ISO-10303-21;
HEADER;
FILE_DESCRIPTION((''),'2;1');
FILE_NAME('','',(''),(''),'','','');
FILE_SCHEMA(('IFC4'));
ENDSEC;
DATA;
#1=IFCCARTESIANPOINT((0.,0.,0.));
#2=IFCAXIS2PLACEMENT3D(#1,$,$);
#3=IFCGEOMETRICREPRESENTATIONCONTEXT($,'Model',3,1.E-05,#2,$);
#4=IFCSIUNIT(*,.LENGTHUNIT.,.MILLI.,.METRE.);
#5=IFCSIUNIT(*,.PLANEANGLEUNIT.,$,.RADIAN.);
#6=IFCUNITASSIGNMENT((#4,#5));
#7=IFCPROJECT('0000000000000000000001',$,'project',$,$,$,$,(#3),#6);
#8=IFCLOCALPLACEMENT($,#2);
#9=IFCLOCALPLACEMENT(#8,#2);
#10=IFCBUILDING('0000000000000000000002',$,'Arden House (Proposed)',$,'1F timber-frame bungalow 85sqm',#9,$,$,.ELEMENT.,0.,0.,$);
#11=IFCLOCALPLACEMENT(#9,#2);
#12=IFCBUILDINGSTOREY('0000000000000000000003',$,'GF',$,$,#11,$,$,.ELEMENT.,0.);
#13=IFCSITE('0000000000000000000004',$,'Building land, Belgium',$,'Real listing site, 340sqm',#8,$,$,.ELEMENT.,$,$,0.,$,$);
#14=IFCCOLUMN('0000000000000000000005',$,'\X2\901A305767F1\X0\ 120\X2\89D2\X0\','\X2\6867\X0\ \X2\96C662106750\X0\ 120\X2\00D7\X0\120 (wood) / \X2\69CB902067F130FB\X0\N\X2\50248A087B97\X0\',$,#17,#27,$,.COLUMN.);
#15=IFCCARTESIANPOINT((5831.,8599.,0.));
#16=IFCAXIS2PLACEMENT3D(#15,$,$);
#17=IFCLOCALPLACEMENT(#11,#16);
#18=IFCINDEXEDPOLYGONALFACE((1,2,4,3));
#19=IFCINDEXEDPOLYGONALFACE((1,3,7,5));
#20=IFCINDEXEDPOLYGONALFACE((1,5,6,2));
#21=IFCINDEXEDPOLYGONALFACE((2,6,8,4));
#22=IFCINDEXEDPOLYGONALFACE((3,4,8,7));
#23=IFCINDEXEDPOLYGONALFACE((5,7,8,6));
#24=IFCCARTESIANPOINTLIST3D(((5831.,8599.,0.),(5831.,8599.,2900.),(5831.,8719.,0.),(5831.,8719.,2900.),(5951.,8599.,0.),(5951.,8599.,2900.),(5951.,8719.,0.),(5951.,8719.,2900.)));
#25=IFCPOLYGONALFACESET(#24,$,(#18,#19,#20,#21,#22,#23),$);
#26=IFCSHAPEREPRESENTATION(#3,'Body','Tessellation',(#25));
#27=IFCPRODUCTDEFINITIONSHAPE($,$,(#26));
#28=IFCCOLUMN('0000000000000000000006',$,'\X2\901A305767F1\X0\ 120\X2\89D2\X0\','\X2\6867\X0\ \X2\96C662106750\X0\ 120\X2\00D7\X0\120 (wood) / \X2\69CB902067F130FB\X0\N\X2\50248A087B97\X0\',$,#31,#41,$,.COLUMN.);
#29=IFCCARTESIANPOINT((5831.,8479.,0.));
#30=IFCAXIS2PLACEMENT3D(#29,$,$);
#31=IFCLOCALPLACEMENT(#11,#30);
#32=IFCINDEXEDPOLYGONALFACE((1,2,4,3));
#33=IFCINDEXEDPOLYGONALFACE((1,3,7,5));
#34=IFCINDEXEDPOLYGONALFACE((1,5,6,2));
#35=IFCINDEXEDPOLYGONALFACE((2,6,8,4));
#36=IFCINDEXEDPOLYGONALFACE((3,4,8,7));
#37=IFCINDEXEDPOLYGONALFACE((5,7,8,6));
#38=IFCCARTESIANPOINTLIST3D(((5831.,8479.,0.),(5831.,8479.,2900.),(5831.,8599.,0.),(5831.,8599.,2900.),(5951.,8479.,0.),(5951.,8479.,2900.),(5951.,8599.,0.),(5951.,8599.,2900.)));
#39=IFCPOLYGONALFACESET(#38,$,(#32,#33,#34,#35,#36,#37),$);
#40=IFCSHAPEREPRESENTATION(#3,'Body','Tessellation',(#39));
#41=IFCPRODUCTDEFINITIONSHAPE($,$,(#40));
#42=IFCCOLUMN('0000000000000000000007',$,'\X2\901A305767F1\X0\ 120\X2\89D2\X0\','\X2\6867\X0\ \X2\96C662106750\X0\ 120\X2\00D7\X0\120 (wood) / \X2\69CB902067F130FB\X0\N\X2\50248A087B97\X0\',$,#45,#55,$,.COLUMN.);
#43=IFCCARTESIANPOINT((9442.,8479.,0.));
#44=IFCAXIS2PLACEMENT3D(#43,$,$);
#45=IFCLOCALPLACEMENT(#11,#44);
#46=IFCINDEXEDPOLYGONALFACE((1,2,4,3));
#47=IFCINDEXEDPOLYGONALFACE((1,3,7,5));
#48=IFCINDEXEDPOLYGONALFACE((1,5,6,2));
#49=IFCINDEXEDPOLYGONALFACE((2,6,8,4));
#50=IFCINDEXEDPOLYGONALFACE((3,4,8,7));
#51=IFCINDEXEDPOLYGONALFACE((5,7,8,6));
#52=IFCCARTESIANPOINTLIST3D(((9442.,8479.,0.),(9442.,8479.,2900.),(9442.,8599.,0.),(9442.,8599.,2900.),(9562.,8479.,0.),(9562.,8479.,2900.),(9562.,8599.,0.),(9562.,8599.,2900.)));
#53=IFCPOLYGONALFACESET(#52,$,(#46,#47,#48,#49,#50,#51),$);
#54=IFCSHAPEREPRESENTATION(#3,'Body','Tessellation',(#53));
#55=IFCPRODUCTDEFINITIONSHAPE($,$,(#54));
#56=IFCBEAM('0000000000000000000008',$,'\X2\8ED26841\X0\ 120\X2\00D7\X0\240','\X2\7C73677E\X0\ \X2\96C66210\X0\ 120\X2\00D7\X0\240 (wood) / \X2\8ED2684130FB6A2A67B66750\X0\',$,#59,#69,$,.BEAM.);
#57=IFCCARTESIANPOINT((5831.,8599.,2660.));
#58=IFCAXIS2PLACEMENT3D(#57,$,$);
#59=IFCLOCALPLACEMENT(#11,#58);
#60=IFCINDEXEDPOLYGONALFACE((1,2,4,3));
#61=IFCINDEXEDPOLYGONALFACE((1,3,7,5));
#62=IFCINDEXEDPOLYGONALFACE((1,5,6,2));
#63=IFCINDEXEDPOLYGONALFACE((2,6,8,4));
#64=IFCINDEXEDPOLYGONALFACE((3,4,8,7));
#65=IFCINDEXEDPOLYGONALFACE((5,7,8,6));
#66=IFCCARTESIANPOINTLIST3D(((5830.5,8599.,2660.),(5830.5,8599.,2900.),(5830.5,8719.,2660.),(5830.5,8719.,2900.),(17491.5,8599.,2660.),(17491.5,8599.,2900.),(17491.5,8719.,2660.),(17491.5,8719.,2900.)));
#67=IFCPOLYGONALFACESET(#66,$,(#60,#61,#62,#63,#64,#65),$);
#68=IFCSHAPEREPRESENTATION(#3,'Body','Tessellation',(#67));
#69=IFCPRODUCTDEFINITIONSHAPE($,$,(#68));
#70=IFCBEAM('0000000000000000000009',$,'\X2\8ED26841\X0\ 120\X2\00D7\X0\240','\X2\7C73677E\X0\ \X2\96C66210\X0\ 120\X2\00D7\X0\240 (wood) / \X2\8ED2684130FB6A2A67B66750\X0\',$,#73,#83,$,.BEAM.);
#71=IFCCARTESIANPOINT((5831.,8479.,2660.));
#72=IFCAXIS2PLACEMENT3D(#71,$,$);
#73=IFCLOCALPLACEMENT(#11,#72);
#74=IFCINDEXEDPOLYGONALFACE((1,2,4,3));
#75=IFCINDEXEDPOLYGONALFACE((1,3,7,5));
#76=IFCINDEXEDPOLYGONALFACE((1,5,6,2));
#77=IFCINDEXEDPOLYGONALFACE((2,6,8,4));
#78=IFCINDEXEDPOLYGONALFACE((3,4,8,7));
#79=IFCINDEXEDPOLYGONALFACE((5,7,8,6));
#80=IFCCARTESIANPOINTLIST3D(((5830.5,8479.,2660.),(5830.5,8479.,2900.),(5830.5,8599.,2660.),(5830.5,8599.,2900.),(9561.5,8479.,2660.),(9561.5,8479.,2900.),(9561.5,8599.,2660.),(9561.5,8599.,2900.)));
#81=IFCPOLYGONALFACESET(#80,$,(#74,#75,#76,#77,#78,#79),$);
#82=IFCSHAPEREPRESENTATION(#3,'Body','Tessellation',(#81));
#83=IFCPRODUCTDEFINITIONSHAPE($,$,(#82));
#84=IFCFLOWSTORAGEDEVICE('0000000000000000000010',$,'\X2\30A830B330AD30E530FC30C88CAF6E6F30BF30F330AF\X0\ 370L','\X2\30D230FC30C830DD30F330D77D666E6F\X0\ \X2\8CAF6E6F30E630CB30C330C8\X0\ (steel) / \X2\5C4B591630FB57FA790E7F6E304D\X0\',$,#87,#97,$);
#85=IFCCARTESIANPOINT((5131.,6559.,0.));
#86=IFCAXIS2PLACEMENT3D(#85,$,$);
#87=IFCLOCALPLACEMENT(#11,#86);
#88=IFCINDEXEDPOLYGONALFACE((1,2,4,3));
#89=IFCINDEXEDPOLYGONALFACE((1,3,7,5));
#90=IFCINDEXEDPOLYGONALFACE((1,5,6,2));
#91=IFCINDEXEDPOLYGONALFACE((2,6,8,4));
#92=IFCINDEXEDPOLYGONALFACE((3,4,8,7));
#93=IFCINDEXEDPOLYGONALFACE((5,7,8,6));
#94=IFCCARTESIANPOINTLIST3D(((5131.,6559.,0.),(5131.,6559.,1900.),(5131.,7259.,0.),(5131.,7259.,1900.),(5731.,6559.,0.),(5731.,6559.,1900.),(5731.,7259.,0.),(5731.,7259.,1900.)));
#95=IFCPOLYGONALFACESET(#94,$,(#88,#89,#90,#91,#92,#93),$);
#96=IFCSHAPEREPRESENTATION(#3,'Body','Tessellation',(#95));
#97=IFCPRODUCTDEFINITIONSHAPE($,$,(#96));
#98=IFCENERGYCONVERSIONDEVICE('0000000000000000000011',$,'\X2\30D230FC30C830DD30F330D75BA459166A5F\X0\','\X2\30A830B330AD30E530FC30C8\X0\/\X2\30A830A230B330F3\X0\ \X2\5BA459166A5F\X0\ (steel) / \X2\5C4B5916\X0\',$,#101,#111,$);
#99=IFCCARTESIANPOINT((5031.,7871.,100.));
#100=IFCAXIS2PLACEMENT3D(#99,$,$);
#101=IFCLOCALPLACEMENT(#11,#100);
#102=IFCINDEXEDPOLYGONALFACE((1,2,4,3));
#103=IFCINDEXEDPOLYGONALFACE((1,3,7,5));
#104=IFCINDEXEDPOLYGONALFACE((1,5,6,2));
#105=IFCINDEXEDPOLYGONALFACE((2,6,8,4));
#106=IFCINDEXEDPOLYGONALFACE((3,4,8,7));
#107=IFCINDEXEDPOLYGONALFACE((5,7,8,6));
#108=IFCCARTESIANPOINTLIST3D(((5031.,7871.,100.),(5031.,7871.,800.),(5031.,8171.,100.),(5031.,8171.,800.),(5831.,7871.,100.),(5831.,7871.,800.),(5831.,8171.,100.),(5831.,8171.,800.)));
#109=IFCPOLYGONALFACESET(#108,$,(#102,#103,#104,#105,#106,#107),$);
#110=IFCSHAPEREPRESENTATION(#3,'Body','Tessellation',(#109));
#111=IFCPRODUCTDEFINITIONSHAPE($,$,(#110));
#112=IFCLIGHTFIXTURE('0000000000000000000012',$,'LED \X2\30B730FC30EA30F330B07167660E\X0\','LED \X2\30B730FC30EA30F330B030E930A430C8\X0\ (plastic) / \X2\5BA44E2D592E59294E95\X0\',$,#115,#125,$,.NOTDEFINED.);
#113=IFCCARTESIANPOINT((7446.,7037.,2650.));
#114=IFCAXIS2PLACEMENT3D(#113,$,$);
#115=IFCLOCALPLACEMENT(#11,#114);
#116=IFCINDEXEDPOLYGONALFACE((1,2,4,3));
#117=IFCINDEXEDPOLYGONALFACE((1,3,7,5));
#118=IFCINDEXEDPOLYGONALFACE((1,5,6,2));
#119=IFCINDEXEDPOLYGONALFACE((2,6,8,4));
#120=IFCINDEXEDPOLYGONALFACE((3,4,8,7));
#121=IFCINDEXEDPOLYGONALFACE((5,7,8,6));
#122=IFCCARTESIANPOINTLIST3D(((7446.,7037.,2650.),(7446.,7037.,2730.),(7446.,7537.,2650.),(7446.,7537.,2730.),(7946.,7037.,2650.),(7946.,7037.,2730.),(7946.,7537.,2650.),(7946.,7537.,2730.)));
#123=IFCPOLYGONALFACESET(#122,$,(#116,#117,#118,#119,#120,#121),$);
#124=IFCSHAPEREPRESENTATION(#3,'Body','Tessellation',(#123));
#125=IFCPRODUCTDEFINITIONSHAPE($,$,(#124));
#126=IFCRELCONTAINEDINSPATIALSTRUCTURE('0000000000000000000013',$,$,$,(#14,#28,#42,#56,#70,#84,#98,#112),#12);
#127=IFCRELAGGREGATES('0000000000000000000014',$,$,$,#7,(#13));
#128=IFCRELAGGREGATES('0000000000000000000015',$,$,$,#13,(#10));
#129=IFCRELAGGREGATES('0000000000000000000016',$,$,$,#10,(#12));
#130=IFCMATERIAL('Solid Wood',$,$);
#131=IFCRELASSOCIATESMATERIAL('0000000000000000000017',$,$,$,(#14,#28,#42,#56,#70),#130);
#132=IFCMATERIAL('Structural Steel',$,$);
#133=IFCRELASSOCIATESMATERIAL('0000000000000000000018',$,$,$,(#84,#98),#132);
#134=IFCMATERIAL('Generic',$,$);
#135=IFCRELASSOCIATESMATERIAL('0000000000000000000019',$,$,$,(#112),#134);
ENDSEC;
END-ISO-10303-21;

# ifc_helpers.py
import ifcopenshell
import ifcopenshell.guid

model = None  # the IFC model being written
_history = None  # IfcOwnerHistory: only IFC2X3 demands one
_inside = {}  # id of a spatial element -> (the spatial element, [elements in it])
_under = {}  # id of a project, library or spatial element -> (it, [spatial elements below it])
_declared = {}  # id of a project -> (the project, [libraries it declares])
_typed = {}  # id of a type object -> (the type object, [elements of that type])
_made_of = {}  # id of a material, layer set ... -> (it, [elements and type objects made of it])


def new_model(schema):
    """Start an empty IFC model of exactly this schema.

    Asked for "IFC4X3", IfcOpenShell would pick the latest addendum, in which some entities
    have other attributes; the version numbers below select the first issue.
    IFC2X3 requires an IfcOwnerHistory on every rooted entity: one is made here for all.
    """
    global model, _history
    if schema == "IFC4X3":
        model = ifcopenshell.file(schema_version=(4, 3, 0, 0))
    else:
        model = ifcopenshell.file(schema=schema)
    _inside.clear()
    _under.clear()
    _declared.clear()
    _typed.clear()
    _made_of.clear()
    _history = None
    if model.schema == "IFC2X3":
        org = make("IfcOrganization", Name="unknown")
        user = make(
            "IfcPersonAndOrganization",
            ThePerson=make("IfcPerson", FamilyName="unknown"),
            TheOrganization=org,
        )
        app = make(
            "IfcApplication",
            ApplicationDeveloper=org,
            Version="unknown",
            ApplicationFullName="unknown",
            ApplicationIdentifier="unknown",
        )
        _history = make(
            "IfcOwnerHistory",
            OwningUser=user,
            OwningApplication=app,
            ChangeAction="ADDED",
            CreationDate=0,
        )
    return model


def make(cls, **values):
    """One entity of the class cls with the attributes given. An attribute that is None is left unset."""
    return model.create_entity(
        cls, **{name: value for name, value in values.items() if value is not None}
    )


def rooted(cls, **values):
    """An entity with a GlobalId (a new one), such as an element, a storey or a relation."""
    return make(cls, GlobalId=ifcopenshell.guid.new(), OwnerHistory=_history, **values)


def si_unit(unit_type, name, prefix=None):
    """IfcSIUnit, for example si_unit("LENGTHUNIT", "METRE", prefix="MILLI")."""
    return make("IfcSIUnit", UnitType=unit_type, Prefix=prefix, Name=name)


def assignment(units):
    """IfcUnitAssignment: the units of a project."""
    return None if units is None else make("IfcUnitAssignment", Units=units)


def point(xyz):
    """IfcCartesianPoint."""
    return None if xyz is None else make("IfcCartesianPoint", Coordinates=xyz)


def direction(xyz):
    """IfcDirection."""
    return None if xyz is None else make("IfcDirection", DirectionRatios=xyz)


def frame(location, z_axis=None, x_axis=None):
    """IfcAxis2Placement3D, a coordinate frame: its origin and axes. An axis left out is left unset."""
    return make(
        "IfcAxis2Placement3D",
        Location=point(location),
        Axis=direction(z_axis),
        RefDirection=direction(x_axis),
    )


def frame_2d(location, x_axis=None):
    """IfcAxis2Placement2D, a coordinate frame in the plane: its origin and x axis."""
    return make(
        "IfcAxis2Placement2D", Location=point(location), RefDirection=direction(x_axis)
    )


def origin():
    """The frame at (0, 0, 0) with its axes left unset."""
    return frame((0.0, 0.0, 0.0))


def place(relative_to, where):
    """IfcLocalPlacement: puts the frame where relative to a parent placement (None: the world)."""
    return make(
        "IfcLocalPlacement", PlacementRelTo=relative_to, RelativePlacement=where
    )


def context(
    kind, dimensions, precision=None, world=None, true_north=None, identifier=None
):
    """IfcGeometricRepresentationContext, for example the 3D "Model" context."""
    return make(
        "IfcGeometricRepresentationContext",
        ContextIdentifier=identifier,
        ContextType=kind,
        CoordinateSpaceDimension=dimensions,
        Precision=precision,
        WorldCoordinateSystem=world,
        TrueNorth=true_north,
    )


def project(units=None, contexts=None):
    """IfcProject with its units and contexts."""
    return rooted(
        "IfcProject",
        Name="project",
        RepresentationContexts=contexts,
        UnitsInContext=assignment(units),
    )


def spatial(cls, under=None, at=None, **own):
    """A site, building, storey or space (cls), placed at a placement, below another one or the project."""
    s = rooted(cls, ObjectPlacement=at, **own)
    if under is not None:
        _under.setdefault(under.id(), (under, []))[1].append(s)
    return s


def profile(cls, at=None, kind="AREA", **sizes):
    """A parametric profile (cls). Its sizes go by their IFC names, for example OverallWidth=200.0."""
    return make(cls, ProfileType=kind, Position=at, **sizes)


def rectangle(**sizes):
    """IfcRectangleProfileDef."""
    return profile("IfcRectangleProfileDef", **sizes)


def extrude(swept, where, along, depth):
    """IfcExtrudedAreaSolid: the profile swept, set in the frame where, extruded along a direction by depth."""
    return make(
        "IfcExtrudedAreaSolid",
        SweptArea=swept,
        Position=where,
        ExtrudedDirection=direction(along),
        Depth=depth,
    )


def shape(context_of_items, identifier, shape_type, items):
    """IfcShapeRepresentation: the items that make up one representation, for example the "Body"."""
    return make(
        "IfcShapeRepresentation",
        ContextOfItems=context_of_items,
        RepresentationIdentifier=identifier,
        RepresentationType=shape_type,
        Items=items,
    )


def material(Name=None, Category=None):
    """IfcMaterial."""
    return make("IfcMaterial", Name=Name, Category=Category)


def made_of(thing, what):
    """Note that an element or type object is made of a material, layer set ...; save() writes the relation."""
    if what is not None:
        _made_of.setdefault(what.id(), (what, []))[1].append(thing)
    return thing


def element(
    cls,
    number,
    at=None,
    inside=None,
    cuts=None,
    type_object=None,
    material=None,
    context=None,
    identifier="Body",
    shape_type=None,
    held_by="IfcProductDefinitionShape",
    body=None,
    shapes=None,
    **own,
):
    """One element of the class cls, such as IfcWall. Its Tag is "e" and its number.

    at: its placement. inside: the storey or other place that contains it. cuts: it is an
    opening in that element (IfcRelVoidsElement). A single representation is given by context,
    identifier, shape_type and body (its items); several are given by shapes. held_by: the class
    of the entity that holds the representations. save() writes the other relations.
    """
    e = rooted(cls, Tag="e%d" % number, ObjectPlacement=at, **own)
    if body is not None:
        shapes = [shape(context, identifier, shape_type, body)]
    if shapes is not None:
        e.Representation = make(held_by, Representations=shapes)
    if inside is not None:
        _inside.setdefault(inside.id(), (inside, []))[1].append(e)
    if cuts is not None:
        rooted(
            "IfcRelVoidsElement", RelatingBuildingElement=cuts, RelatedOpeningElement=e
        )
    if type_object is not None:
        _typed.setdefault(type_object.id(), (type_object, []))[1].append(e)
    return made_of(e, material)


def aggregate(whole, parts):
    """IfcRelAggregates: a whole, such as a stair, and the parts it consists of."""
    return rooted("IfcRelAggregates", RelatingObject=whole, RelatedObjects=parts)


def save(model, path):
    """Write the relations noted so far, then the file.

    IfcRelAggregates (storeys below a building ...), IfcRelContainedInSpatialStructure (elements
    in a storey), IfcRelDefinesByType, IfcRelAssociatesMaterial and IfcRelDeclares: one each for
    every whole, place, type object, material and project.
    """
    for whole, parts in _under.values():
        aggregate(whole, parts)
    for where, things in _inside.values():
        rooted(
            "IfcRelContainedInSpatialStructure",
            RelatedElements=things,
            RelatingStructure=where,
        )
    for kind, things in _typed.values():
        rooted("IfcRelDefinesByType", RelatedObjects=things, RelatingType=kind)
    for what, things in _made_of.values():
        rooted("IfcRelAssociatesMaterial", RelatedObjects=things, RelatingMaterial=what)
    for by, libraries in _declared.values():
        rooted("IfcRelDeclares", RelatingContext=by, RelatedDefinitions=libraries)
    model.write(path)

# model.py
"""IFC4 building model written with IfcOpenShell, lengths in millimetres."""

from ifc_helpers import new_model, si_unit, frame, frame_2d, origin, place, context, project, spatial, rectangle, extrude, material, element, save


model = new_model("IFC4")

# Units and contexts
model_context = context("Model", 3, precision=1e-05, world=origin())
ifc_project = project(units=[si_unit("LENGTHUNIT", "METRE", prefix="MILLI"), si_unit("PLANEANGLEUNIT", "RADIAN")], contexts=[model_context])

# Site, building, storey
site_placement = place(None, origin())
site = spatial("IfcSite", under=ifc_project, at=site_placement, Name="Building land, Belgium", ObjectType="Real listing site, 340sqm", CompositionType="ELEMENT", RefElevation=0.0)
building_placement = place(site_placement, origin())
building = spatial("IfcBuilding", under=site, at=building_placement, Name="Arden House (Proposed)", ObjectType="1F timber-frame bungalow 85sqm", CompositionType="ELEMENT", ElevationOfRefHeight=0.0, ElevationOfTerrain=0.0)
storey_placement = place(building_placement, origin())
storey = spatial("IfcBuildingStorey", under=building, at=storey_placement, Name="GF", CompositionType="ELEMENT", Elevation=0.0)

# Columns
ifc_material_1 = material(Name="Solid Wood")
column_1_placement = place(storey_placement, frame((5831.0, 8599.0, 0.0)))
element("IfcColumn", 1, at=column_1_placement, inside=storey, material=ifc_material_1, Name="通し柱 120角", Description="桧 集成材 120×120 (wood) / 構造柱・N値計算", PredefinedType="COLUMN", context=model_context, shape_type="SweptSolid", body=[
    extrude(rectangle(XDim=120.0, YDim=120.0, at=frame_2d((60.0, 60.0))), frame((5831.0, 8599.0, 0.0)), (0.0, 0.0, 1.0), 2900.0),
])
column_2_placement = place(storey_placement, frame((5831.0, 8479.0, 0.0)))
element("IfcColumn", 2, at=column_2_placement, inside=storey, material=ifc_material_1, Name="通し柱 120角", Description="桧 集成材 120×120 (wood) / 構造柱・N値計算", PredefinedType="COLUMN", context=model_context, shape_type="SweptSolid", body=[
    extrude(rectangle(XDim=120.0, YDim=120.0, at=frame_2d((60.0, 60.0))), frame((5831.0, 8479.0, 0.0)), (0.0, 0.0, 1.0), 2900.0),
])
column_3_placement = place(storey_placement, frame((9442.0, 8479.0, 0.0)))
element("IfcColumn", 3, at=column_3_placement, inside=storey, material=ifc_material_1, Name="通し柱 120角", Description="桧 集成材 120×120 (wood) / 構造柱・N値計算", PredefinedType="COLUMN", context=model_context, shape_type="SweptSolid", body=[
    extrude(rectangle(XDim=120.0, YDim=120.0, at=frame_2d((60.0, 60.0))), frame((9442.0, 8479.0, 0.0)), (0.0, 0.0, 1.0), 2900.0),
])

# Beams
beam_1_placement = place(storey_placement, frame((5831.0, 8599.0, 2660.0)))
element("IfcBeam", 4, at=beam_1_placement, inside=storey, material=ifc_material_1, Name="軒桁 120×240", Description="米松 集成 120×240 (wood) / 軒桁・横架材", PredefinedType="BEAM", context=model_context, shape_type="SweptSolid", body=[
    extrude(rectangle(XDim=11661.0, YDim=120.0, at=frame_2d((5830.0, 60.0))), frame((5831.0, 8599.0, 2660.0)), (0.0, 0.0, 1.0), 240.0),
])
beam_2_placement = place(storey_placement, frame((5831.0, 8479.0, 2660.0)))
element("IfcBeam", 5, at=beam_2_placement, inside=storey, material=ifc_material_1, Name="軒桁 120×240", Description="米松 集成 120×240 (wood) / 軒桁・横架材", PredefinedType="BEAM", context=model_context, shape_type="SweptSolid", body=[
    extrude(rectangle(XDim=3731.0, YDim=120.0, at=frame_2d((1865.0, 60.0))), frame((5831.0, 8479.0, 2660.0)), (0.0, 0.0, 1.0), 240.0),
])

# Shared definitions
ifc_material_2 = material(Name="Structural Steel")

# Shared definitions
ifc_material_3 = material(Name="Generic")

# Flow storage device
flow_storage_device_placement = place(storey_placement, frame((5131.0, 6559.0, 0.0)))
element("IfcFlowStorageDevice", 6, at=flow_storage_device_placement, inside=storey, material=ifc_material_2, Name="エコキュート貯湯タンク 370L", Description="ヒートポンプ給湯 貯湯ユニット (steel) / 屋外・基礎置き", context=model_context, shape_type="SweptSolid", body=[
    extrude(rectangle(XDim=600.0, YDim=700.0, at=frame_2d((300.0, 350.0))), frame((5131.0, 6559.0, 0.0)), (0.0, 0.0, 1.0), 1900.0),
])

# Energy conversion device
energy_conversion_device_placement = place(storey_placement, frame((5031.0, 7871.0, 100.0)))
element("IfcEnergyConversionDevice", 7, at=energy_conversion_device_placement, inside=storey, material=ifc_material_2, Name="ヒートポンプ室外機", Description="エコキュート/エアコン 室外機 (steel) / 屋外", context=model_context, shape_type="SweptSolid", body=[
    extrude(rectangle(XDim=800.0, YDim=300.0, at=frame_2d((400.0, 150.0))), frame((5031.0, 7871.0, 100.0)), (0.0, 0.0, 1.0), 700.0),
])

# Light fixture
light_fixture_placement = place(storey_placement, frame((7446.0, 7037.0, 2650.0)))
element("IfcLightFixture", 8, at=light_fixture_placement, inside=storey, material=ifc_material_3, Name="LED シーリング照明", Description="LED シーリングライト (plastic) / 室中央天井", PredefinedType="NOTDEFINED", context=model_context, shape_type="SweptSolid", body=[
    extrude(rectangle(XDim=500.0, YDim=500.0, at=frame_2d((250.0, 250.0))), frame((7446.0, 7037.0, 2650.0)), (0.0, 0.0, 1.0), 80.0),
])

save(model, "model.ifc")
